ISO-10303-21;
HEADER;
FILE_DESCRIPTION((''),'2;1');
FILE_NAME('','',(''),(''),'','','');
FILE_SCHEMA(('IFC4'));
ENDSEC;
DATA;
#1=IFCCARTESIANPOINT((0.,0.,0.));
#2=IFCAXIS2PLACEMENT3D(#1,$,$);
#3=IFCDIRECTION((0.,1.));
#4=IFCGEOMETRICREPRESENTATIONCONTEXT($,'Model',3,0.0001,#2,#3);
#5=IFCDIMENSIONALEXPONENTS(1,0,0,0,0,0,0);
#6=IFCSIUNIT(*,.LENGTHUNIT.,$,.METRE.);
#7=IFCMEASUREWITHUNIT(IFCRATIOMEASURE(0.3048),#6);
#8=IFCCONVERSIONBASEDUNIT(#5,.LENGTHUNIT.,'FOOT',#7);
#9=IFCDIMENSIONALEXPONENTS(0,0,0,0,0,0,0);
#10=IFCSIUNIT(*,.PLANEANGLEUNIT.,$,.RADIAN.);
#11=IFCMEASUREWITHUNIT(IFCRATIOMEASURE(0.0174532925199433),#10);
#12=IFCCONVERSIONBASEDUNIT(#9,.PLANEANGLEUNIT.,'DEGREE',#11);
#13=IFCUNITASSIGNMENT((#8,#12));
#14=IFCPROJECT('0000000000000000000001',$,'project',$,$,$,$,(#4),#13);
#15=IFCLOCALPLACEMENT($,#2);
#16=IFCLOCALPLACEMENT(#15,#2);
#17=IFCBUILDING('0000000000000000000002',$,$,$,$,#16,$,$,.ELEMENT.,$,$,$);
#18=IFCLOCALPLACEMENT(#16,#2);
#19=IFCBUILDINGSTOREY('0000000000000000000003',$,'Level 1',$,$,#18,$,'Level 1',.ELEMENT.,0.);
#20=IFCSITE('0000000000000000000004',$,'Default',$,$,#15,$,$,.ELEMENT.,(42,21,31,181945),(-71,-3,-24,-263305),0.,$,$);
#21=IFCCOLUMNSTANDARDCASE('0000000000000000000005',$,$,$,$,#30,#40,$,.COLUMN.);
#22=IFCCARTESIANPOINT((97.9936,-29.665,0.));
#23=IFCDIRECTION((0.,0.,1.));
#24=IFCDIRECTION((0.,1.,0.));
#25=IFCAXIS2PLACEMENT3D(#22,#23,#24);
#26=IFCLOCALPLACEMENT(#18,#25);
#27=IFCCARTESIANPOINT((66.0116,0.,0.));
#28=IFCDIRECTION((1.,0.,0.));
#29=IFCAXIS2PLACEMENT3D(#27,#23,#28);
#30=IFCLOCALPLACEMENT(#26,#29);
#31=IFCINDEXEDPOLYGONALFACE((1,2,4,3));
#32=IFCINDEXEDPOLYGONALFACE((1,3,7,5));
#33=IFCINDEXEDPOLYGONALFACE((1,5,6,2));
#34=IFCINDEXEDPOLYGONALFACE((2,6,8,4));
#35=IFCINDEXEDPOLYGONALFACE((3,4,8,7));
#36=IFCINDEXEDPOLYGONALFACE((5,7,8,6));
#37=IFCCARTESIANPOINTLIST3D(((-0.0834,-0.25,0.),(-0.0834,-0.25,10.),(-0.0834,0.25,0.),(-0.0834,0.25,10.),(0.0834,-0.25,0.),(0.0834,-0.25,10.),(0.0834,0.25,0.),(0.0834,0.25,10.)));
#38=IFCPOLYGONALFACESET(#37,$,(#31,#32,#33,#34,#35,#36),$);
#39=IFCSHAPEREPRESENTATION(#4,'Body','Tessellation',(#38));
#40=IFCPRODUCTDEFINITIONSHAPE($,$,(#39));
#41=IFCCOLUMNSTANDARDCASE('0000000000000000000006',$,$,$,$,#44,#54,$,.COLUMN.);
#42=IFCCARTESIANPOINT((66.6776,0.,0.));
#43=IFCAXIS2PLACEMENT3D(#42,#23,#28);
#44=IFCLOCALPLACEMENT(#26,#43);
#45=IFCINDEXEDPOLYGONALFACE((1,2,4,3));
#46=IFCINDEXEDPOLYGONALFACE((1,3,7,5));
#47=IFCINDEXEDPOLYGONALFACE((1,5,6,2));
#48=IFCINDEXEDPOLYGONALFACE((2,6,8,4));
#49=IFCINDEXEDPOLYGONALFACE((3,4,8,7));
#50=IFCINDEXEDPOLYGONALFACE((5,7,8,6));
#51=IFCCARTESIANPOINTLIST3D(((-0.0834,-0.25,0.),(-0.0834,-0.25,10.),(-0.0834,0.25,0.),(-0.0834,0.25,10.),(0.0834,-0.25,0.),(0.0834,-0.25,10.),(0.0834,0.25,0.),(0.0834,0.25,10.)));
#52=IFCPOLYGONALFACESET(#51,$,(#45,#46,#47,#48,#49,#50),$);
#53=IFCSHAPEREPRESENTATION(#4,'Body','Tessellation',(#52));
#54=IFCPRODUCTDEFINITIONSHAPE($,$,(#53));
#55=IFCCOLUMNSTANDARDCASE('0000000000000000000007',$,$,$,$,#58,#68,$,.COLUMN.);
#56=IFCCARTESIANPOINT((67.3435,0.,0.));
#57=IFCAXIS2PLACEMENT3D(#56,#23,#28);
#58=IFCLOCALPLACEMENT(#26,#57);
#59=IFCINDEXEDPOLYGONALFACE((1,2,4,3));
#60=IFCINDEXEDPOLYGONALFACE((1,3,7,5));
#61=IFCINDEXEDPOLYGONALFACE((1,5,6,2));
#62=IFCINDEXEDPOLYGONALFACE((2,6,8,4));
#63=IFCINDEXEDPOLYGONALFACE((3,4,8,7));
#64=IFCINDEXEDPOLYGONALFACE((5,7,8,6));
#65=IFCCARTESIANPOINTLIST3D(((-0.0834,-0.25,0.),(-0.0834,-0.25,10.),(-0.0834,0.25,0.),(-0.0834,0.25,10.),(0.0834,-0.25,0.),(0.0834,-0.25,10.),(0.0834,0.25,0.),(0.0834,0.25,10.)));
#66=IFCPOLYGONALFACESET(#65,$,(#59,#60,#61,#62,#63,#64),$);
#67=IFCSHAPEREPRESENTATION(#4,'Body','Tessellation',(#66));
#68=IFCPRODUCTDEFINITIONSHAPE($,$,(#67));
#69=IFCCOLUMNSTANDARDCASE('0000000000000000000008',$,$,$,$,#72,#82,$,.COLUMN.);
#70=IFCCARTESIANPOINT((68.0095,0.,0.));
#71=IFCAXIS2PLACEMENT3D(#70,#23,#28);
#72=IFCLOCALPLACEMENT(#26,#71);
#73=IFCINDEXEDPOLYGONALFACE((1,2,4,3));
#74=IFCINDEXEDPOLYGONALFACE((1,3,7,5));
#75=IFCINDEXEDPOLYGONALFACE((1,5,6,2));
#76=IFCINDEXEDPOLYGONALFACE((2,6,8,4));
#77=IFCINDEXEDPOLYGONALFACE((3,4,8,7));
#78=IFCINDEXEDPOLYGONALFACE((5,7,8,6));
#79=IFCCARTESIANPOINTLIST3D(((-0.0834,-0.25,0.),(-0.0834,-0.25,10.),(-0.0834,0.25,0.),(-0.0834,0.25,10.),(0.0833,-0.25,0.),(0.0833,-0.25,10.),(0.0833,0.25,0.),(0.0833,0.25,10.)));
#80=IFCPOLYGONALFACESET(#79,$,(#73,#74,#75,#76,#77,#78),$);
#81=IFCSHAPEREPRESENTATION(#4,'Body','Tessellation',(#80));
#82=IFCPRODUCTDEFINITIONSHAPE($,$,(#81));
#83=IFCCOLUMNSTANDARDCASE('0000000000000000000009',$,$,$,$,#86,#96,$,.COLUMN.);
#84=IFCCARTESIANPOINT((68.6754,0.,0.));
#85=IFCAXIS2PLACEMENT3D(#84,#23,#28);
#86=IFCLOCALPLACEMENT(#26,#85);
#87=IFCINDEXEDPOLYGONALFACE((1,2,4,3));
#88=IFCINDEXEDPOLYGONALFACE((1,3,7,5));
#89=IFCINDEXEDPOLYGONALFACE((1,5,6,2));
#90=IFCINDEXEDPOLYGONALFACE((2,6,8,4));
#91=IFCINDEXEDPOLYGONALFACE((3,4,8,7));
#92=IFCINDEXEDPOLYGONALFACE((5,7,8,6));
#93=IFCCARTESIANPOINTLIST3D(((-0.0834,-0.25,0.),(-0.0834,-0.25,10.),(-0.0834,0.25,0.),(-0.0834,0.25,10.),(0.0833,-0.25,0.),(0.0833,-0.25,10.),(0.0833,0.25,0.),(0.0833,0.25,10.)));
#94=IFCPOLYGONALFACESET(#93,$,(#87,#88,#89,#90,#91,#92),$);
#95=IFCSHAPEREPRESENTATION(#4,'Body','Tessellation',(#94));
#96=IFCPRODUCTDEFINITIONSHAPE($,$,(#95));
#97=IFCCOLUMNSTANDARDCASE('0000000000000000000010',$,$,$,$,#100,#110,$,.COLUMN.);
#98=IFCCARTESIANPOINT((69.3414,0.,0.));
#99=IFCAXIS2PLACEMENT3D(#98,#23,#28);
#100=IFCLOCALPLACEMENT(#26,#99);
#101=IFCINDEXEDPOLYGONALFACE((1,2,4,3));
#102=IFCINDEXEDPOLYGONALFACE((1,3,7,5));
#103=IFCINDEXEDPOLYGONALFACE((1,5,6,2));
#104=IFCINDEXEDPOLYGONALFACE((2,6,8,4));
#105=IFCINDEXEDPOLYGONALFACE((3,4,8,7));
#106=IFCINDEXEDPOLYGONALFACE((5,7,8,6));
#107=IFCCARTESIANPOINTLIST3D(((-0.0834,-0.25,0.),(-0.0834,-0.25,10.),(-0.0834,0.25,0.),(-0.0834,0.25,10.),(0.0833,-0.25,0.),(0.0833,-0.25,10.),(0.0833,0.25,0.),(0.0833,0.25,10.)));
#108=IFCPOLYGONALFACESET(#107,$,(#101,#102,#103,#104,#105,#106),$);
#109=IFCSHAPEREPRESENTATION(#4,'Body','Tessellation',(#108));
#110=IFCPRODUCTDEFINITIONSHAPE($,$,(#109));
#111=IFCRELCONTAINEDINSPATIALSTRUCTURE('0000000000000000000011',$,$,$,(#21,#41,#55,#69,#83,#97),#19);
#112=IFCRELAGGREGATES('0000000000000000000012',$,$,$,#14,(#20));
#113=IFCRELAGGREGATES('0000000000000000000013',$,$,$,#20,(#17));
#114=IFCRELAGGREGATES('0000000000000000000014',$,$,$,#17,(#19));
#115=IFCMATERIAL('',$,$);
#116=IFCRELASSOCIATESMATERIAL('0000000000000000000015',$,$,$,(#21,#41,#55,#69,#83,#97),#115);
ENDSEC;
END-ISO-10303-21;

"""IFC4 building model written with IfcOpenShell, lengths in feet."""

from ifc_helpers import new_model, entity, si_unit, converted_unit, direction, frame, origin, place, context, project, spatial, rectangle, extrude, material, element, save


model = new_model("IFC4")

# Units and contexts
model_context = context("Model", 3, precision=0.0001, world=origin(), true_north=direction((0.0, 1.0)))
ifc_project = project(units=[converted_unit("LENGTHUNIT", "FOOT", entity("IfcRatioMeasure", 0.3048), si_unit("LENGTHUNIT", "METRE"), dimensions=[1, 0, 0, 0, 0, 0, 0]), converted_unit("PLANEANGLEUNIT", "DEGREE", entity("IfcRatioMeasure", 0.0174532925199433), si_unit("PLANEANGLEUNIT", "RADIAN"), dimensions=[0, 0, 0, 0, 0, 0, 0])], contexts=[model_context])

# Site, building, storey
site_placement = place(None, origin())
site = spatial("IfcSite", under=ifc_project, at=site_placement, Name="Default", CompositionType="ELEMENT", RefLatitude=(42, 21, 31, 181945), RefLongitude=(-71, -3, -24, -263305), RefElevation=0.0)
building_placement = place(site_placement, origin())
building = spatial("IfcBuilding", under=site, at=building_placement, CompositionType="ELEMENT")
storey_placement = place(building_placement, origin())
storey = spatial("IfcBuildingStorey", under=building, at=storey_placement, Name="Level 1", LongName="Level 1", CompositionType="ELEMENT", Elevation=0.0)

# Columns
ifc_material = material(Name="")
placement_1 = place(storey_placement, frame((97.9936, -29.665, 0.0), z_axis=(0.0, 0.0, 1.0), x_axis=(0.0, 1.0, 0.0)))
for number, where, z_axis, x_axis in (
    (1, (66.0116, 0.0, 0.0), (0.0, 0.0, 1.0), (1.0, 0.0, 0.0)),
    (2, (66.6776, 0.0, 0.0), (0.0, 0.0, 1.0), (1.0, 0.0, 0.0)),
    (3, (67.3435, 0.0, 0.0), (0.0, 0.0, 1.0), (1.0, 0.0, 0.0)),
    (4, (68.0095, 0.0, 0.0), (0.0, 0.0, 1.0), (1.0, 0.0, 0.0)),
    (5, (68.6754, 0.0, 0.0), (0.0, 0.0, 1.0), (1.0, 0.0, 0.0)),
    (6, (69.3414, 0.0, 0.0), (0.0, 0.0, 1.0), (1.0, 0.0, 0.0)),
):
    element("IfcColumnStandardCase", number, at=place(placement_1, frame(where, z_axis=z_axis, x_axis=x_axis)), inside=storey, material=ifc_material, PredefinedType="COLUMN", context=model_context, shape_type="SweptSolid", body=[
        extrude(rectangle(XDim=0.1667, YDim=0.5), origin(), (0.0, 0.0, 1.0), 10.0),
    ])

save(model, "model.ifc")
